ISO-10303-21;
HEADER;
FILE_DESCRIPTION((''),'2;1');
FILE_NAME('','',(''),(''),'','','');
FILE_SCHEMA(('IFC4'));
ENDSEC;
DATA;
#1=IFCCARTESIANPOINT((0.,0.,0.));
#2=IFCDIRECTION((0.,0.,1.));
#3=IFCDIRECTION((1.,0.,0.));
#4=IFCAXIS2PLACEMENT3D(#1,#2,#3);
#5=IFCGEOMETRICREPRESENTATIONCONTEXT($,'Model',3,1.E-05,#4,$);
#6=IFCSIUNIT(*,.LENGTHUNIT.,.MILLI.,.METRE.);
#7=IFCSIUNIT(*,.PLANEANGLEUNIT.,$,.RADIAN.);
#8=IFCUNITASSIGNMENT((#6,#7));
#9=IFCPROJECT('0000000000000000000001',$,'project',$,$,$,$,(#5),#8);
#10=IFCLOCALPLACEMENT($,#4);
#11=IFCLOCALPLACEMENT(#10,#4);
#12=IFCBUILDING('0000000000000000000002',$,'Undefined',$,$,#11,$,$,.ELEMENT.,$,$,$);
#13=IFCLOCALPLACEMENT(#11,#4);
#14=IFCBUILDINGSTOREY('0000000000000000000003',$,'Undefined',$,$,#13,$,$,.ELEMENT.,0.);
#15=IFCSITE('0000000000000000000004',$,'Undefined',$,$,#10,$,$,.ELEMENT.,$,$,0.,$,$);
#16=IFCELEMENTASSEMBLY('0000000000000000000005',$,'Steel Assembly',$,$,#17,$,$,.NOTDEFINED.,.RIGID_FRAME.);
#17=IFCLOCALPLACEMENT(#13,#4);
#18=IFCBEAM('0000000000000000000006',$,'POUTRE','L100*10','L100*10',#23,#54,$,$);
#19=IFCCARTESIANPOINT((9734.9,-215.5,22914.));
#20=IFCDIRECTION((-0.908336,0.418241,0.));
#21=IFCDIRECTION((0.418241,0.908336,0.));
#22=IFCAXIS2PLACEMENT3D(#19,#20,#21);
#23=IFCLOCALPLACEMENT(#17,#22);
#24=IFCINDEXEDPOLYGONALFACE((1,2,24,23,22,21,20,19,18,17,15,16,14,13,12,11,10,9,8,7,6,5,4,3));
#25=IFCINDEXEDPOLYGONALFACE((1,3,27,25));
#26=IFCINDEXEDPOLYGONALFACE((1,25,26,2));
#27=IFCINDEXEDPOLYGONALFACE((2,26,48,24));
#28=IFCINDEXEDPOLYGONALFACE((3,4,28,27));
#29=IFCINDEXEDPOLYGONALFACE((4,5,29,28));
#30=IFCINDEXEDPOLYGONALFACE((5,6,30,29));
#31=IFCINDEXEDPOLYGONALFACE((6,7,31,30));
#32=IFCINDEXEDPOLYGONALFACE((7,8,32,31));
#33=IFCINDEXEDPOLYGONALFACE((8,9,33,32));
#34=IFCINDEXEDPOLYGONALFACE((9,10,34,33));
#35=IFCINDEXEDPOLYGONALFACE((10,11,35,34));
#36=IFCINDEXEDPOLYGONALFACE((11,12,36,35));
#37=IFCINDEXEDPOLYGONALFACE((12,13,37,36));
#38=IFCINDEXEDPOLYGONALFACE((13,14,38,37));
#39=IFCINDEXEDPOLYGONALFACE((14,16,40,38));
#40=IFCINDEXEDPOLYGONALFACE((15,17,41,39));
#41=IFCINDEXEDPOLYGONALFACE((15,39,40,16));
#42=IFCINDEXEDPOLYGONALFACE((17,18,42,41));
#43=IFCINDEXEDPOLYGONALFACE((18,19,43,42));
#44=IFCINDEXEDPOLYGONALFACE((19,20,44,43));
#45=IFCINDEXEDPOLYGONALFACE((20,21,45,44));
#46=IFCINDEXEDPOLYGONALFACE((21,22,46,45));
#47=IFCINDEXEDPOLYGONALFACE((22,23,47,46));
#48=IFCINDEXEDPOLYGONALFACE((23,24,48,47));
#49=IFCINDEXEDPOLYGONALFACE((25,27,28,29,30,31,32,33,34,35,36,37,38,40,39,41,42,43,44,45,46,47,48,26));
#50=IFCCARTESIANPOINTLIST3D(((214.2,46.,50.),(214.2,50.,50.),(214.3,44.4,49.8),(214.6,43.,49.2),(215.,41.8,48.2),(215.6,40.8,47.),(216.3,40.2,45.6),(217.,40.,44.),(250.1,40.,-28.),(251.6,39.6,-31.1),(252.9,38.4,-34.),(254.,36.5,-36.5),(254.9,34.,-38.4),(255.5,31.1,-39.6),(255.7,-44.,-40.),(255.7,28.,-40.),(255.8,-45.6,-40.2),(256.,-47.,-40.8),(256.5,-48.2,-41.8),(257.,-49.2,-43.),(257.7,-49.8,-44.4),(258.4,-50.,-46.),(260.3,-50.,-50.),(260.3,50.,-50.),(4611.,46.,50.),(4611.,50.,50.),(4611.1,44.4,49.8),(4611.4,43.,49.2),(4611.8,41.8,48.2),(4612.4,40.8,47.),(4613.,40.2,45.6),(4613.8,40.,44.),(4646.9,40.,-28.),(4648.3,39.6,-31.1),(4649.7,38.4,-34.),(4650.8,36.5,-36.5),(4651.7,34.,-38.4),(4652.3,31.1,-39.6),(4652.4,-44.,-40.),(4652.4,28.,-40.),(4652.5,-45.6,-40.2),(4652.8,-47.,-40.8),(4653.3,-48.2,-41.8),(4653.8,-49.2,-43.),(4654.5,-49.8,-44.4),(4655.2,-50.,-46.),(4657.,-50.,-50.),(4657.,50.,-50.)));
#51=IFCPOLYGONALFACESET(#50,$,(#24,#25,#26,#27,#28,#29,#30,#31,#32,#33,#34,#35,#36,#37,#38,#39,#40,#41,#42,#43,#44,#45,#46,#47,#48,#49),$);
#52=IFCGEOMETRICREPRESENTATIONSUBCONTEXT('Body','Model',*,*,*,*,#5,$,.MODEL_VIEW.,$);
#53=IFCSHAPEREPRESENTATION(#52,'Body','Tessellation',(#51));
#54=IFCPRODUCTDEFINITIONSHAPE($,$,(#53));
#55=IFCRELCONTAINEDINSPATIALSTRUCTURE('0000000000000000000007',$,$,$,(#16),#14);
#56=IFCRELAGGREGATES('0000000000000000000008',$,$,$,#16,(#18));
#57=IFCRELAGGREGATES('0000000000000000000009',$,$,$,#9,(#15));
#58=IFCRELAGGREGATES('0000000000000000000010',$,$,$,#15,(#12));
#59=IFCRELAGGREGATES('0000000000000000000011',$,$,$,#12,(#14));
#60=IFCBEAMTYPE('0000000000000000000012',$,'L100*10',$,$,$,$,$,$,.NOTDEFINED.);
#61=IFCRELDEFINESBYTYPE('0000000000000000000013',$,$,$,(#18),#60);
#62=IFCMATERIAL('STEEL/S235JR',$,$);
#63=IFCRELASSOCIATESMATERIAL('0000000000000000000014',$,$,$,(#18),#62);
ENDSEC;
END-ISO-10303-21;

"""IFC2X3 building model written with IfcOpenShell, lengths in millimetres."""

from ifc_helpers import new_model, si_unit, frame, origin_with_axes, origin_2d_with_axis, place, context, subcontext, project, spatial, l_section, extrude, clip, halfspace, material, type_object, element, aggregate, save


model = new_model("IFC2X3")

# Units and contexts
model_context = context("Model", 3, precision=1e-05, world=origin_with_axes())
body_context = subcontext(model_context, "Body", "Model", "MODEL_VIEW")
ifc_project = project(units=[si_unit("LENGTHUNIT", "METRE", prefix="MILLI"), si_unit("PLANEANGLEUNIT", "RADIAN")], contexts=[model_context])

# Site, building, storey
site_placement = place(None, origin_with_axes())
site = spatial("IfcSite", under=ifc_project, at=site_placement, Name="Undefined", CompositionType="ELEMENT", RefElevation=0.0)
building_placement = place(site_placement, origin_with_axes())
building = spatial("IfcBuilding", under=site, at=building_placement, Name="Undefined", CompositionType="ELEMENT")
storey_placement = place(building_placement, origin_with_axes())
storey = spatial("IfcBuildingStorey", under=building, at=storey_placement, Name="Undefined", CompositionType="ELEMENT", Elevation=0.0)

# Element assembly, beam
ifc_material_1 = material(Name="STEEL/S235JR")
beam_type_1 = type_object("IfcBeamType", Name="L100*10", PredefinedType="NOTDEFINED")
assembly_1_placement = place(storey_placement, origin_with_axes())
assembly_1 = element("IfcElementAssembly", 1, at=assembly_1_placement, inside=storey, Name="Steel Assembly", AssemblyPlace="NOTDEFINED", PredefinedType="RIGID_FRAME")
beam_1_placement = place(assembly_1_placement, frame((9734.9, -215.5, 22914.0), z_axis=(-0.908336, 0.418241, 0.0), x_axis=(0.418241, 0.908336, 0.0)))
beam_1 = element("IfcBeam", 2, at=beam_1_placement, type_object=beam_type_1, material=ifc_material_1, Name="POUTRE", Description="L100*10", ObjectType="L100*10", context=body_context, shape_type="Clipping", body=[
    clip(clip(extrude(l_section(Depth=100.0, Width=100.0, Thickness=10.0, FilletRadius=12.0, EdgeRadius=6.0, at=origin_2d_with_axis()), frame((4680.5, 0.0, 0.0), z_axis=(-1.0, 0.0, 0.0), x_axis=(0.0, -1.0, 0.0)), (0.0, 0.0, 1.0), 4489.8), halfspace(frame((4598.3, -215.0, 77.6), z_axis=(0.908336, 0.0, 0.418241), x_axis=(0.418241, 0.0, -0.908336)), False)), halfspace(frame((260.3, -215.0, -50.0), z_axis=(-0.908336, 0.0, -0.418241), x_axis=(-0.418241, 0.0, 0.908336)), False)),
])

aggregate(assembly_1, [beam_1])

save(model, "model.ifc")
